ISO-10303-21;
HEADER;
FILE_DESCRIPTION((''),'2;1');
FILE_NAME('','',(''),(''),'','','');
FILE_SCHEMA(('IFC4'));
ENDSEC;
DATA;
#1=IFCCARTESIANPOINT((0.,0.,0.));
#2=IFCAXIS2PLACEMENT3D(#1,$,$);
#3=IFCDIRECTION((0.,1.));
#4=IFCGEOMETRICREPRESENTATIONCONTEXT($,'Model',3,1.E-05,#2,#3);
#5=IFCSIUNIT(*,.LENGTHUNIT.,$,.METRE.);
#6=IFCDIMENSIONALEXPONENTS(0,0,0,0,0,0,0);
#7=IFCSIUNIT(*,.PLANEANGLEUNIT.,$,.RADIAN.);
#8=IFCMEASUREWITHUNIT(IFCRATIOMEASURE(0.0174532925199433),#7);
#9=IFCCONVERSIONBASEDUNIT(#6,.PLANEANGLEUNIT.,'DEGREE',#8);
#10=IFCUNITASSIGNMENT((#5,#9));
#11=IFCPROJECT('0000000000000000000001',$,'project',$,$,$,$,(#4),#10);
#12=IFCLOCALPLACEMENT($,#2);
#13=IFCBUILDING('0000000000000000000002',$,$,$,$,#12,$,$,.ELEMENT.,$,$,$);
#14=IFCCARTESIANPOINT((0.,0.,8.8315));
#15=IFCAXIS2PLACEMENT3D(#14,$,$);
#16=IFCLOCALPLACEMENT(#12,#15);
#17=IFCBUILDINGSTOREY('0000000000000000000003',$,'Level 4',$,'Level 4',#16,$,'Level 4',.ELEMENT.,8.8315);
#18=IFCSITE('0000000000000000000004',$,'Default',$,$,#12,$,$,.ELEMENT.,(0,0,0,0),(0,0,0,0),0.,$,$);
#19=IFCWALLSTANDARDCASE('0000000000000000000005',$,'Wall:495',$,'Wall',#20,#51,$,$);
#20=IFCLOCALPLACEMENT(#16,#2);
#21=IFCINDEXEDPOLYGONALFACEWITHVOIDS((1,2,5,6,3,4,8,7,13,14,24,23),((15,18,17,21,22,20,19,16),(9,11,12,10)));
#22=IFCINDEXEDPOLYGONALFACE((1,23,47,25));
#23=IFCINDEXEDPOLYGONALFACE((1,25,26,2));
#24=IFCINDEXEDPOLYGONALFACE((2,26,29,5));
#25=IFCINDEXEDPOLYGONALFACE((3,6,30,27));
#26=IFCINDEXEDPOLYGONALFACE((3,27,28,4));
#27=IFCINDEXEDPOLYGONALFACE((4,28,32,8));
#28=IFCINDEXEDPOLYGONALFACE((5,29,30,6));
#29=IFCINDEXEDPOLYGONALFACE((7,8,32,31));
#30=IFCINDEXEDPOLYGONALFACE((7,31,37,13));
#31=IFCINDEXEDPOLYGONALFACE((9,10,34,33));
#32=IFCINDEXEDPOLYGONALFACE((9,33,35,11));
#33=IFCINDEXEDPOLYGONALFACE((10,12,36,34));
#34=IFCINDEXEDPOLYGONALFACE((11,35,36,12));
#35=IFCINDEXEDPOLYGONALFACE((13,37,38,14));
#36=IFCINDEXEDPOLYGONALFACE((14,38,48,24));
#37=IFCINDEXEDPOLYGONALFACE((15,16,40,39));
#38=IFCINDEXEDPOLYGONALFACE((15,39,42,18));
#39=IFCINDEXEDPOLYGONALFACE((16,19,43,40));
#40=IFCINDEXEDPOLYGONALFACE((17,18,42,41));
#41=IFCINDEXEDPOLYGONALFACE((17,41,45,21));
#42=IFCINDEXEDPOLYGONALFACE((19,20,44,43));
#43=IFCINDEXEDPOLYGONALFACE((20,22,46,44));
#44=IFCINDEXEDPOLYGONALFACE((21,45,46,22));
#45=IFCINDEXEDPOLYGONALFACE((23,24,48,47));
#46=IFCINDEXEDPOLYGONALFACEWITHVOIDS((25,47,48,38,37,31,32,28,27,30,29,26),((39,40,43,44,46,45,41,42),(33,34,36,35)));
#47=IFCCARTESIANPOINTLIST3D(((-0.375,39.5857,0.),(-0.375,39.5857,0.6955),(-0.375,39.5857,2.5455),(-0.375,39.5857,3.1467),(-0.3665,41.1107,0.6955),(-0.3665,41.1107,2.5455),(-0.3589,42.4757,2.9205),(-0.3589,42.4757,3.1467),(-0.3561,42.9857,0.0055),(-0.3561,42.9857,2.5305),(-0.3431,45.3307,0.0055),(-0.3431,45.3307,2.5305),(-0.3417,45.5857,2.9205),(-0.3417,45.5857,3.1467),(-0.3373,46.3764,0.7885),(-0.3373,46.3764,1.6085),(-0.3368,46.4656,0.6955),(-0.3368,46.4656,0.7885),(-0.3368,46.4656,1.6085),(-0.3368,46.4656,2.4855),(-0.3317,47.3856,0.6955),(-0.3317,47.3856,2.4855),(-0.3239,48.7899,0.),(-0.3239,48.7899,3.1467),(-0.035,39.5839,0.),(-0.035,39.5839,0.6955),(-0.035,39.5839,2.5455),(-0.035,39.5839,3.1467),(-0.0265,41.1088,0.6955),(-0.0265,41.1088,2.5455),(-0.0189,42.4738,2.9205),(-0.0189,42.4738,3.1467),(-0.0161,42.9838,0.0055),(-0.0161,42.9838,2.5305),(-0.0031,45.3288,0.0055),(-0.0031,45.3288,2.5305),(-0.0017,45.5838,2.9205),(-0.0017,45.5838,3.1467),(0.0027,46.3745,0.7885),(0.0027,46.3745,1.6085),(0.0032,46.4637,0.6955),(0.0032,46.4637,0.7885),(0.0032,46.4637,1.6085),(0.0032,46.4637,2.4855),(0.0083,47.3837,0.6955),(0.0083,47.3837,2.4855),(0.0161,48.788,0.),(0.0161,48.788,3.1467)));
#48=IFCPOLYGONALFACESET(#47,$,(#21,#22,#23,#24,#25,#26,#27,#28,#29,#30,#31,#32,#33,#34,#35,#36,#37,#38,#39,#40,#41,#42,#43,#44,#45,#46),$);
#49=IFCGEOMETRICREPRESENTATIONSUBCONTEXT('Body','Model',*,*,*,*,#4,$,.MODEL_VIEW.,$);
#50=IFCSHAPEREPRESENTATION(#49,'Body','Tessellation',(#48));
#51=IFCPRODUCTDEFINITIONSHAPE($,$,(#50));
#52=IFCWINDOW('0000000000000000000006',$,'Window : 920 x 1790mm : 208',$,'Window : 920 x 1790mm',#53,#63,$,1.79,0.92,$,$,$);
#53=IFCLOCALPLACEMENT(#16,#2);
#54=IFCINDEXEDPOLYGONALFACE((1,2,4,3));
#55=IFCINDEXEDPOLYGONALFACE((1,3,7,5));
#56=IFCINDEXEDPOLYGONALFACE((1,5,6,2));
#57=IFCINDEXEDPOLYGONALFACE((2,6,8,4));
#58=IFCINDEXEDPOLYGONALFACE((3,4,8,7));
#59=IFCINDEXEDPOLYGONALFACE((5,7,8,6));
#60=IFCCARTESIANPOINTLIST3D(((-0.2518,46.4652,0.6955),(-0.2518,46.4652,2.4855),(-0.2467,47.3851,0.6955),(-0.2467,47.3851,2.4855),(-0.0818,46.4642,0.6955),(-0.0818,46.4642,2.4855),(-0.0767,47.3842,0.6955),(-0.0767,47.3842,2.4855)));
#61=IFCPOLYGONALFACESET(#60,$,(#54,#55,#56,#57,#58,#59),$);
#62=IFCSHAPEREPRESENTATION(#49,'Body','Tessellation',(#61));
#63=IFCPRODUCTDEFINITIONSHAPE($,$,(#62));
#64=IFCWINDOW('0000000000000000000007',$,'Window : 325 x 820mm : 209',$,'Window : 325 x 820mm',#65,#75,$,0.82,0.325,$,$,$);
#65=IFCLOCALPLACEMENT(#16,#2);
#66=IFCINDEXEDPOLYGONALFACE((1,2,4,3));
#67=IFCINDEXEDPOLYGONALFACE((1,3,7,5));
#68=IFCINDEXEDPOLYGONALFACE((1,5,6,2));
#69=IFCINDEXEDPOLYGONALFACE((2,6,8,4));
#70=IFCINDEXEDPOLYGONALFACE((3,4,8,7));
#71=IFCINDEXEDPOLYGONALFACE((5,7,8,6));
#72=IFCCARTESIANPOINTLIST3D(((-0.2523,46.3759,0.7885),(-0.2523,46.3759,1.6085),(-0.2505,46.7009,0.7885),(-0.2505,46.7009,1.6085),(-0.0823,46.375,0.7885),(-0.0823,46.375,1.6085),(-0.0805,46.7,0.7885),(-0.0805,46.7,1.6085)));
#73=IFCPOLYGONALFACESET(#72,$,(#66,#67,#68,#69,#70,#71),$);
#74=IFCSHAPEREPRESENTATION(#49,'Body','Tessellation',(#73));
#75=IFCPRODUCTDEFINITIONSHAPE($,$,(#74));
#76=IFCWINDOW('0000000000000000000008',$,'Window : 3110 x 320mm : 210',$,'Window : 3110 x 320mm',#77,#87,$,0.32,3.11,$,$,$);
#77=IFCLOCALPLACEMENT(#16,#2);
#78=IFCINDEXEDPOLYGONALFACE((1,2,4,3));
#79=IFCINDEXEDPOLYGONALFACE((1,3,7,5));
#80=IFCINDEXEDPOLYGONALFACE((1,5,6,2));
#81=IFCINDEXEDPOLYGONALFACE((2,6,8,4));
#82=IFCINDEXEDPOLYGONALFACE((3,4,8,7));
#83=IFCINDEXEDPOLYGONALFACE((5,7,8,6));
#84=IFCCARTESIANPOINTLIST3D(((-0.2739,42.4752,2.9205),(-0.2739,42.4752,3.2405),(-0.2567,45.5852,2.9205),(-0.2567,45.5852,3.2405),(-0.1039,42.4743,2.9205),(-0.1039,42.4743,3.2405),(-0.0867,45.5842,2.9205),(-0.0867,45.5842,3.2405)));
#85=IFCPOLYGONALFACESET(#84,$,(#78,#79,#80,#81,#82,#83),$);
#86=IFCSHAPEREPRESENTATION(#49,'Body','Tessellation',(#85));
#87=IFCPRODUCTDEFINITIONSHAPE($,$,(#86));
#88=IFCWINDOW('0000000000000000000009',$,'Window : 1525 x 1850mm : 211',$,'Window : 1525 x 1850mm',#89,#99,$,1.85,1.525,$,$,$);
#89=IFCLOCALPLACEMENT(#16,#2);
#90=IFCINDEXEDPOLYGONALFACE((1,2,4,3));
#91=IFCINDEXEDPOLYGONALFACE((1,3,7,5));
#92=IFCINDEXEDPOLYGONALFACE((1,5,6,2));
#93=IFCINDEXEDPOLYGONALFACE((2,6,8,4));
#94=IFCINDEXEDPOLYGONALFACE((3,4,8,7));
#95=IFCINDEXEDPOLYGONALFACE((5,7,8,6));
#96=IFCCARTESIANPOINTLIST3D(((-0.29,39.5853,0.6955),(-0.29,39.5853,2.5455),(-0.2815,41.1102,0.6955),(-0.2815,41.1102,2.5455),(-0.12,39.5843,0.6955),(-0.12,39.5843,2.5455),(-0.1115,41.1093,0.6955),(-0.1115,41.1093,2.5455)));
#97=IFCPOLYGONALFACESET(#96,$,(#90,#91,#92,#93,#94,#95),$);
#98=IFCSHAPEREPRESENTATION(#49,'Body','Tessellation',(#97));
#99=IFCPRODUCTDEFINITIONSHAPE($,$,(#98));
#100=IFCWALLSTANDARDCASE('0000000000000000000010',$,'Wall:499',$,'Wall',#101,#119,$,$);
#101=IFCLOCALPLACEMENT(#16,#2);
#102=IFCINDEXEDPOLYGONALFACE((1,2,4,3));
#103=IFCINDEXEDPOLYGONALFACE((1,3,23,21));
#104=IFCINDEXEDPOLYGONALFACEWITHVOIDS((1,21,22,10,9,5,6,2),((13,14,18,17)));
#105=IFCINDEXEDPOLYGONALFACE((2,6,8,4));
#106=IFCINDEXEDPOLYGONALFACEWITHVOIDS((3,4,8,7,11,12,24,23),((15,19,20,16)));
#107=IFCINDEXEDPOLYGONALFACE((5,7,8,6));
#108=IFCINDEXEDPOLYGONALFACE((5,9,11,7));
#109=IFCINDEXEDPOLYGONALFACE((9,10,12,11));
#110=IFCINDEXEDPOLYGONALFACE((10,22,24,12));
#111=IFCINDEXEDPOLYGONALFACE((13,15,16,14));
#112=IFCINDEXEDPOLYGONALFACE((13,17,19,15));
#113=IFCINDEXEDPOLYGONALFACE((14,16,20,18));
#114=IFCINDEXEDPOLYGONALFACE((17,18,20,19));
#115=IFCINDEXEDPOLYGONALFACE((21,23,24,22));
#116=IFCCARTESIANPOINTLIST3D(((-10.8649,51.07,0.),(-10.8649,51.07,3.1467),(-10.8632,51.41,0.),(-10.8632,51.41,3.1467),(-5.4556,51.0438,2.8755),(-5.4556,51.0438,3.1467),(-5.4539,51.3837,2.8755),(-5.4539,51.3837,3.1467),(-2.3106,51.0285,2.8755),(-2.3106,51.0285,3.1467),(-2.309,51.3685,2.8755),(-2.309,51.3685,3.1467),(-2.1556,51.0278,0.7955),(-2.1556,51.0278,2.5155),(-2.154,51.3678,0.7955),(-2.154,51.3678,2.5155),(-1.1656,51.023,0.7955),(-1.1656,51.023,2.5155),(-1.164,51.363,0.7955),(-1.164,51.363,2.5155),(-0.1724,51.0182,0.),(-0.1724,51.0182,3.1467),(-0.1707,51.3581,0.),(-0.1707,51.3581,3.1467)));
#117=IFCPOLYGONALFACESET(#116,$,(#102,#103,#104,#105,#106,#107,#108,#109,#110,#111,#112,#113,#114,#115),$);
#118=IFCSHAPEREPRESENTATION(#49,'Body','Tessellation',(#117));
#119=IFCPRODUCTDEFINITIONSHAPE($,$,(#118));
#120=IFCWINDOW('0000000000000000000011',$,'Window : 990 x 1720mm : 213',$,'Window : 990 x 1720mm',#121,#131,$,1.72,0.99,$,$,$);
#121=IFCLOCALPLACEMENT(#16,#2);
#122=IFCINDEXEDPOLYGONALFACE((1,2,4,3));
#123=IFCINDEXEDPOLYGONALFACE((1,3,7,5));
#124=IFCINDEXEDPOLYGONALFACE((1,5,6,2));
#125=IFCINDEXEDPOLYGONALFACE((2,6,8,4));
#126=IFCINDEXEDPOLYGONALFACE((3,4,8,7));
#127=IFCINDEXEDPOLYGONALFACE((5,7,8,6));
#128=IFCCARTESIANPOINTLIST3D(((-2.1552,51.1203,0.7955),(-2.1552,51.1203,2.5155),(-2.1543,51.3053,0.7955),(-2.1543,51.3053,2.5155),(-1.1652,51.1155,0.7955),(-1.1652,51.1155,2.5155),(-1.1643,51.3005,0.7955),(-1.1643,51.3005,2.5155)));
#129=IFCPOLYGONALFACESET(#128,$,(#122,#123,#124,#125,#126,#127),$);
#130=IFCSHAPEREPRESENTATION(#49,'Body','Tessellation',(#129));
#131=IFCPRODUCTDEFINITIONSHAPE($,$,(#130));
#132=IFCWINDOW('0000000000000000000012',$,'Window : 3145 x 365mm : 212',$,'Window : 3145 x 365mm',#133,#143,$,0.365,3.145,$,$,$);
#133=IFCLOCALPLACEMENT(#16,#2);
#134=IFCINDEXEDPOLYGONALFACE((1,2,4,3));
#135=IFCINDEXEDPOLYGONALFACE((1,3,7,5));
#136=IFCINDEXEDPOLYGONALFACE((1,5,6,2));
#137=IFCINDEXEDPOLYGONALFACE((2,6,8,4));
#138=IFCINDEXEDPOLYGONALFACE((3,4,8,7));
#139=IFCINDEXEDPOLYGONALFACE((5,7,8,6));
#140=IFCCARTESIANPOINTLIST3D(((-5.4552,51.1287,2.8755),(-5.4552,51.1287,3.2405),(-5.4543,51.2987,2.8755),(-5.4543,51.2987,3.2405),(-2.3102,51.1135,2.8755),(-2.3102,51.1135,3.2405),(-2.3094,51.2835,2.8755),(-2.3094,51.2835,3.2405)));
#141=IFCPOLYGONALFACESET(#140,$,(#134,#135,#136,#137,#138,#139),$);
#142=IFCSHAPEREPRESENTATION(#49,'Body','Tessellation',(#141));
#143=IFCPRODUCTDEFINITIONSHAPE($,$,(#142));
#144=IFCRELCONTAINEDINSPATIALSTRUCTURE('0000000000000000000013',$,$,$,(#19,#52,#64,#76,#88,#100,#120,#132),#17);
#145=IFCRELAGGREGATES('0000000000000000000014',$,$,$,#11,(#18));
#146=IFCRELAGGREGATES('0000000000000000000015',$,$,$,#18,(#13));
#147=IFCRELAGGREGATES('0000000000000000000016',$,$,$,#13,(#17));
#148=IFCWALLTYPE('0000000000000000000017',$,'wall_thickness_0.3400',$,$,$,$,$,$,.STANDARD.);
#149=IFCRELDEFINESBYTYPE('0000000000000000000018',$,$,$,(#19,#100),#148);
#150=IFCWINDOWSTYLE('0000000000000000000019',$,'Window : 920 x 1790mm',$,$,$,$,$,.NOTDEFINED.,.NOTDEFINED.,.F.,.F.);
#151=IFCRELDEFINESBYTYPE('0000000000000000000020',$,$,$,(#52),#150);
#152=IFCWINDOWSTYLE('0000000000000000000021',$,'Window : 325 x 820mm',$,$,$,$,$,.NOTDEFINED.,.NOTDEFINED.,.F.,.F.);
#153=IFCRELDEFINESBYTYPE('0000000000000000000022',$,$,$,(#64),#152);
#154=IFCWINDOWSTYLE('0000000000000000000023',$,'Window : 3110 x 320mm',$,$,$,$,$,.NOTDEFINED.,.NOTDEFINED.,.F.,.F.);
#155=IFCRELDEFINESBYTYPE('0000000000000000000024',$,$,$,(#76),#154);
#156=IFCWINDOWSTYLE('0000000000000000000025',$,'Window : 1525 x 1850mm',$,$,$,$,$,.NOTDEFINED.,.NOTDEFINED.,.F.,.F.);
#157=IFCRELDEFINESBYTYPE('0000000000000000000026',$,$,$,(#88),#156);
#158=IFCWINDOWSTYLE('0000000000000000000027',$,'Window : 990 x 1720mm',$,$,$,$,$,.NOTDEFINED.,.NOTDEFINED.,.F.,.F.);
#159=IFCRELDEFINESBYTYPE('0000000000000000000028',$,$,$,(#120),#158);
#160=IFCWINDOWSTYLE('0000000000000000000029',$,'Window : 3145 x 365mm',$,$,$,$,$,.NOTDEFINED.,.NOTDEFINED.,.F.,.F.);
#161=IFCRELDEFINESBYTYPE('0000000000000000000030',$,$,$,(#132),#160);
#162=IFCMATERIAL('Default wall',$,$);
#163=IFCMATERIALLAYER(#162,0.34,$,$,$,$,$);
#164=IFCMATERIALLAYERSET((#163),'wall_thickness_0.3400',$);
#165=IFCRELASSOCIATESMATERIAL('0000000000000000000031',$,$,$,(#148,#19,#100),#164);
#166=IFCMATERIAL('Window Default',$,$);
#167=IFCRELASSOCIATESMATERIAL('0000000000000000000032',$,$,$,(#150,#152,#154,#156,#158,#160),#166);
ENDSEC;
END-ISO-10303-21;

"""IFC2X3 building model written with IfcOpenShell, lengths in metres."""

from ifc_helpers import new_model, entity, si_unit, converted_unit, direction, frame, frame_2d, origin, origin_2d_with_axis, place, context, subcontext, project, spatial, polyline, rectangle, outline, extrude, source, transform, mapped, material, layer, layer_set, layer_usage, type_object, type_shapes, element, fill, save


model = new_model("IFC2X3")

# Units and contexts
model_context = context("Model", 3, precision=1e-05, world=origin(), true_north=direction((0.0, 1.0)))
body_context = subcontext(model_context, "Body", "Model", "MODEL_VIEW")
ifc_project = project(units=[si_unit("LENGTHUNIT", "METRE"), converted_unit("PLANEANGLEUNIT", "DEGREE", entity("IfcRatioMeasure", 0.0174532925199433), si_unit("PLANEANGLEUNIT", "RADIAN"), dimensions=[0, 0, 0, 0, 0, 0, 0])], contexts=[model_context])

# Site, building, storey
placement_1 = place(None, origin())
site = spatial("IfcSite", under=ifc_project, at=placement_1, Name="Default", CompositionType="ELEMENT", RefLatitude=(0, 0, 0, 0), RefLongitude=(0, 0, 0, 0), RefElevation=0.0)
building = spatial("IfcBuilding", under=site, at=placement_1, CompositionType="ELEMENT")
storey_placement = place(placement_1, frame((0.0, 0.0, 8.8315)))
storey = spatial("IfcBuildingStorey", under=building, at=storey_placement, Name="Level 4", ObjectType="Level 4", LongName="Level 4", CompositionType="ELEMENT", Elevation=8.8315)

# Shared definitions
ifc_material_1 = material(Name="Default wall")

# Shared definitions
ifc_material_2 = material(Name="Window Default")

# Walls, openings, windows
ifc_layer_1 = layer(ifc_material_1, 0.34)
ifc_layer_set_1 = layer_set([ifc_layer_1], Name="wall_thickness_0.3400")
ifc_layer_usage_1 = layer_usage(ifc_layer_set_1, "AXIS2", "POSITIVE", -0.17)
wall_type_1 = type_object("IfcWallType", Name="wall_thickness_0.3400", PredefinedType="STANDARD", material=ifc_layer_set_1)
wall_1_placement = place(storey_placement, frame((-0.1539, 48.7889, 0.0), z_axis=(0.0, 0.0, 1.0), x_axis=(-0.005553, -0.999985, 0.0)))
wall_1 = element("IfcWallStandardCase", 1, at=wall_1_placement, inside=storey, type_object=wall_type_1, material=ifc_layer_usage_1, Name="Wall:495", ObjectType="Wall", context=body_context, shape_type="SweptSolid", body=[
    extrude(outline(polyline([(9.2043, -0.17), (9.2043, 0.17), (0.0, 0.17), (0.0, -0.17), (9.2043, -0.17)])), origin(), (0.0, 0.0, 1.0), 3.1467),
])
opening_1_placement = place(wall_1_placement, frame((3.4593, -0.17, 0.0055)))
element("IfcOpeningElement", 2, at=opening_1_placement, cuts=wall_1, ObjectType="Opening", context=body_context, shape_type="SweptSolid", body=[
    extrude(rectangle(XDim=2.345, YDim=2.525, at=frame_2d((1.2625, 1.1725), x_axis=(0.0, 1.0))), frame((0.0, 0.0, 0.0), z_axis=(0.0, 1.0, 0.0), x_axis=(0.0, 0.0, 1.0)), (0.0, 0.0, 1.0), 0.34),
])
opening_2_placement = place(wall_1_placement, frame((1.4043, -0.17, 0.6955)))
opening_2 = element("IfcOpeningElement", 3, at=opening_2_placement, cuts=wall_1, ObjectType="Opening", context=body_context, shape_type="SweptSolid", body=[
    extrude(rectangle(XDim=0.92, YDim=1.79, at=frame_2d((0.895, 0.46), x_axis=(0.0, 1.0))), frame((0.0, 0.0, 0.0), z_axis=(0.0, 1.0, 0.0), x_axis=(0.0, 0.0, 1.0)), (0.0, 0.0, 1.0), 0.34),
])
opening_3_placement = place(wall_1_placement, frame((2.0885, -0.17, 0.7885)))
opening_3 = element("IfcOpeningElement", 4, at=opening_3_placement, cuts=wall_1, ObjectType="Opening", context=body_context, shape_type="SweptSolid", body=[
    extrude(rectangle(XDim=0.325, YDim=0.82, at=frame_2d((0.41, 0.1625), x_axis=(0.0, 1.0))), frame((0.0, 0.0, 0.0), z_axis=(0.0, 1.0, 0.0), x_axis=(0.0, 0.0, 1.0)), (0.0, 0.0, 1.0), 0.34),
])
opening_4_placement = place(wall_1_placement, frame((3.2043, -0.17, 2.9205)))
opening_4 = element("IfcOpeningElement", 5, at=opening_4_placement, cuts=wall_1, ObjectType="Opening", context=body_context, shape_type="SweptSolid", body=[
    extrude(rectangle(XDim=3.11, YDim=0.32, at=frame_2d((0.16, 1.555), x_axis=(0.0, 1.0))), frame((0.0, 0.0, 0.0), z_axis=(0.0, 1.0, 0.0), x_axis=(0.0, 0.0, 1.0)), (0.0, 0.0, 1.0), 0.34),
])
opening_5_placement = place(wall_1_placement, frame((7.6793, -0.17, 0.6955)))
opening_5 = element("IfcOpeningElement", 6, at=opening_5_placement, cuts=wall_1, ObjectType="Opening", context=body_context, shape_type="SweptSolid", body=[
    extrude(rectangle(XDim=1.525, YDim=1.85, at=frame_2d((0.925, 0.7625), x_axis=(0.0, 1.0))), frame((0.0, 0.0, 0.0), z_axis=(0.0, 1.0, 0.0), x_axis=(0.0, 0.0, 1.0)), (0.0, 0.0, 1.0), 0.34),
])
window_style_1 = type_object("IfcWindowStyle", Name="Window : 920 x 1790mm", ConstructionType="NOTDEFINED", OperationType="NOTDEFINED", ParameterTakesPrecedence=False, Sizeable=False, material=ifc_material_2)
shared_shape_1 = source(origin(), body_context, "Body", "SweptSolid", [
    extrude(rectangle(XDim=0.17, YDim=0.92, at=origin_2d_with_axis()), frame((0.46, 0.17, 0.0), z_axis=(0.0, 0.0, 1.0), x_axis=(0.0, 1.0, 0.0)), (0.0, 0.0, 1.0), 1.79),
])
type_shapes(window_style_1, [shared_shape_1])
window_1_placement = place(opening_2_placement, origin())
window_1 = element("IfcWindow", 7, at=window_1_placement, inside=storey, type_object=window_style_1, Name="Window : 920 x 1790mm : 208", ObjectType="Window : 920 x 1790mm", OverallHeight=1.79, OverallWidth=0.92, context=body_context, shape_type="MappedRepresentation", body=[
    mapped(shared_shape_1, transform((0.0, 0.0, 0.0), scale=1.0)),
])
fill(opening_2, window_1)
window_style_2 = type_object("IfcWindowStyle", Name="Window : 325 x 820mm", ConstructionType="NOTDEFINED", OperationType="NOTDEFINED", ParameterTakesPrecedence=False, Sizeable=False, material=ifc_material_2)
shared_shape_2 = source(origin(), body_context, "Body", "SweptSolid", [
    extrude(rectangle(XDim=0.17, YDim=0.325, at=origin_2d_with_axis()), frame((0.1625, 0.17, 0.0), z_axis=(0.0, 0.0, 1.0), x_axis=(0.0, 1.0, 0.0)), (0.0, 0.0, 1.0), 0.82),
])
type_shapes(window_style_2, [shared_shape_2])
window_2_placement = place(opening_3_placement, origin())
window_2 = element("IfcWindow", 8, at=window_2_placement, inside=storey, type_object=window_style_2, Name="Window : 325 x 820mm : 209", ObjectType="Window : 325 x 820mm", OverallHeight=0.82, OverallWidth=0.325, context=body_context, shape_type="MappedRepresentation", body=[
    mapped(shared_shape_2, transform((0.0, 0.0, 0.0), scale=1.0)),
])
fill(opening_3, window_2)
window_style_3 = type_object("IfcWindowStyle", Name="Window : 3110 x 320mm", ConstructionType="NOTDEFINED", OperationType="NOTDEFINED", ParameterTakesPrecedence=False, Sizeable=False, material=ifc_material_2)
shared_shape_3 = source(origin(), body_context, "Body", "SweptSolid", [
    extrude(rectangle(XDim=0.17, YDim=3.11, at=origin_2d_with_axis()), frame((1.555, 0.17, 0.0), z_axis=(0.0, 0.0, 1.0), x_axis=(0.0, 1.0, 0.0)), (0.0, 0.0, 1.0), 0.32),
])
type_shapes(window_style_3, [shared_shape_3])
window_3_placement = place(opening_4_placement, origin())
window_3 = element("IfcWindow", 9, at=window_3_placement, inside=storey, type_object=window_style_3, Name="Window : 3110 x 320mm : 210", ObjectType="Window : 3110 x 320mm", OverallHeight=0.32, OverallWidth=3.11, context=body_context, shape_type="MappedRepresentation", body=[
    mapped(shared_shape_3, transform((0.0, 0.0, 0.0), scale=1.0)),
])
fill(opening_4, window_3)
window_style_4 = type_object("IfcWindowStyle", Name="Window : 1525 x 1850mm", ConstructionType="NOTDEFINED", OperationType="NOTDEFINED", ParameterTakesPrecedence=False, Sizeable=False, material=ifc_material_2)
shared_shape_4 = source(origin(), body_context, "Body", "SweptSolid", [
    extrude(rectangle(XDim=0.17, YDim=1.525, at=origin_2d_with_axis()), frame((0.7625, 0.17, 0.0), z_axis=(0.0, 0.0, 1.0), x_axis=(0.0, 1.0, 0.0)), (0.0, 0.0, 1.0), 1.85),
])
type_shapes(window_style_4, [shared_shape_4])
window_4_placement = place(opening_5_placement, origin())
window_4 = element("IfcWindow", 10, at=window_4_placement, inside=storey, type_object=window_style_4, Name="Window : 1525 x 1850mm : 211", ObjectType="Window : 1525 x 1850mm", OverallHeight=1.85, OverallWidth=1.525, context=body_context, shape_type="MappedRepresentation", body=[
    mapped(shared_shape_4, transform((0.0, 0.0, 0.0), scale=1.0)),
])
fill(opening_5, window_4)
wall_2_placement = place(storey_placement, frame((-10.8641, 51.24, 0.0), z_axis=(0.0, 0.0, 1.0), x_axis=(0.999988, -0.004846, 0.0)))
wall_2 = element("IfcWallStandardCase", 11, at=wall_2_placement, inside=storey, type_object=wall_type_1, material=ifc_layer_usage_1, Name="Wall:499", ObjectType="Wall", context=body_context, shape_type="SweptSolid", body=[
    extrude(outline(polyline([(10.6926, -0.17), (10.6926, 0.17), (0.0, 0.17), (0.0, -0.17), (10.6926, -0.17)])), origin(), (0.0, 0.0, 1.0), 3.1467),
])
opening_6_placement = place(wall_2_placement, frame((5.4094, -0.17, 2.8755)))
opening_6 = element("IfcOpeningElement", 12, at=opening_6_placement, cuts=wall_2, ObjectType="Opening", context=body_context, shape_type="SweptSolid", body=[
    extrude(rectangle(XDim=3.145, YDim=0.365, at=frame_2d((0.1825, 1.5725), x_axis=(0.0, 1.0))), frame((0.0, 0.0, 0.0), z_axis=(0.0, 1.0, 0.0), x_axis=(0.0, 0.0, 1.0)), (0.0, 0.0, 1.0), 0.34),
])
opening_7_placement = place(wall_2_placement, frame((8.7094, -0.17, 0.7955)))
opening_7 = element("IfcOpeningElement", 13, at=opening_7_placement, cuts=wall_2, ObjectType="Opening", context=body_context, shape_type="SweptSolid", body=[
    extrude(rectangle(XDim=0.99, YDim=1.72, at=frame_2d((0.86, 0.495), x_axis=(0.0, 1.0))), frame((0.0, 0.0, 0.0), z_axis=(0.0, 1.0, 0.0), x_axis=(0.0, 0.0, 1.0)), (0.0, 0.0, 1.0), 0.34),
])
window_style_5 = type_object("IfcWindowStyle", Name="Window : 990 x 1720mm", ConstructionType="NOTDEFINED", OperationType="NOTDEFINED", ParameterTakesPrecedence=False, Sizeable=False, material=ifc_material_2)
shared_shape_5 = source(origin(), body_context, "Body", "SweptSolid", [
    extrude(rectangle(XDim=0.185, YDim=0.99, at=origin_2d_with_axis()), frame((0.495, 0.185, 0.0), z_axis=(0.0, 0.0, 1.0), x_axis=(0.0, 1.0, 0.0)), (0.0, 0.0, 1.0), 1.72),
])
type_shapes(window_style_5, [shared_shape_5])
window_5_placement = place(opening_7_placement, origin())
window_5 = element("IfcWindow", 14, at=window_5_placement, inside=storey, type_object=window_style_5, Name="Window : 990 x 1720mm : 213", ObjectType="Window : 990 x 1720mm", OverallHeight=1.72, OverallWidth=0.99, context=body_context, shape_type="MappedRepresentation", body=[
    mapped(shared_shape_5, transform((0.0, 0.0, 0.0), scale=1.0)),
])
fill(opening_7, window_5)
window_style_6 = type_object("IfcWindowStyle", Name="Window : 3145 x 365mm", ConstructionType="NOTDEFINED", OperationType="NOTDEFINED", ParameterTakesPrecedence=False, Sizeable=False, material=ifc_material_2)
shared_shape_6 = source(origin(), body_context, "Body", "SweptSolid", [
    extrude(rectangle(XDim=0.17, YDim=3.145, at=origin_2d_with_axis()), frame((1.5725, 0.17, 0.0), z_axis=(0.0, 0.0, 1.0), x_axis=(0.0, 1.0, 0.0)), (0.0, 0.0, 1.0), 0.365),
])
type_shapes(window_style_6, [shared_shape_6])
window_6_placement = place(opening_6_placement, origin())
window_6 = element("IfcWindow", 15, at=window_6_placement, inside=storey, type_object=window_style_6, Name="Window : 3145 x 365mm : 212", ObjectType="Window : 3145 x 365mm", OverallHeight=0.365, OverallWidth=3.145, context=body_context, shape_type="MappedRepresentation", body=[
    mapped(shared_shape_6, transform((0.0, 0.0, 0.0), scale=1.0)),
])
fill(opening_6, window_6)

save(model, "model.ifc")
